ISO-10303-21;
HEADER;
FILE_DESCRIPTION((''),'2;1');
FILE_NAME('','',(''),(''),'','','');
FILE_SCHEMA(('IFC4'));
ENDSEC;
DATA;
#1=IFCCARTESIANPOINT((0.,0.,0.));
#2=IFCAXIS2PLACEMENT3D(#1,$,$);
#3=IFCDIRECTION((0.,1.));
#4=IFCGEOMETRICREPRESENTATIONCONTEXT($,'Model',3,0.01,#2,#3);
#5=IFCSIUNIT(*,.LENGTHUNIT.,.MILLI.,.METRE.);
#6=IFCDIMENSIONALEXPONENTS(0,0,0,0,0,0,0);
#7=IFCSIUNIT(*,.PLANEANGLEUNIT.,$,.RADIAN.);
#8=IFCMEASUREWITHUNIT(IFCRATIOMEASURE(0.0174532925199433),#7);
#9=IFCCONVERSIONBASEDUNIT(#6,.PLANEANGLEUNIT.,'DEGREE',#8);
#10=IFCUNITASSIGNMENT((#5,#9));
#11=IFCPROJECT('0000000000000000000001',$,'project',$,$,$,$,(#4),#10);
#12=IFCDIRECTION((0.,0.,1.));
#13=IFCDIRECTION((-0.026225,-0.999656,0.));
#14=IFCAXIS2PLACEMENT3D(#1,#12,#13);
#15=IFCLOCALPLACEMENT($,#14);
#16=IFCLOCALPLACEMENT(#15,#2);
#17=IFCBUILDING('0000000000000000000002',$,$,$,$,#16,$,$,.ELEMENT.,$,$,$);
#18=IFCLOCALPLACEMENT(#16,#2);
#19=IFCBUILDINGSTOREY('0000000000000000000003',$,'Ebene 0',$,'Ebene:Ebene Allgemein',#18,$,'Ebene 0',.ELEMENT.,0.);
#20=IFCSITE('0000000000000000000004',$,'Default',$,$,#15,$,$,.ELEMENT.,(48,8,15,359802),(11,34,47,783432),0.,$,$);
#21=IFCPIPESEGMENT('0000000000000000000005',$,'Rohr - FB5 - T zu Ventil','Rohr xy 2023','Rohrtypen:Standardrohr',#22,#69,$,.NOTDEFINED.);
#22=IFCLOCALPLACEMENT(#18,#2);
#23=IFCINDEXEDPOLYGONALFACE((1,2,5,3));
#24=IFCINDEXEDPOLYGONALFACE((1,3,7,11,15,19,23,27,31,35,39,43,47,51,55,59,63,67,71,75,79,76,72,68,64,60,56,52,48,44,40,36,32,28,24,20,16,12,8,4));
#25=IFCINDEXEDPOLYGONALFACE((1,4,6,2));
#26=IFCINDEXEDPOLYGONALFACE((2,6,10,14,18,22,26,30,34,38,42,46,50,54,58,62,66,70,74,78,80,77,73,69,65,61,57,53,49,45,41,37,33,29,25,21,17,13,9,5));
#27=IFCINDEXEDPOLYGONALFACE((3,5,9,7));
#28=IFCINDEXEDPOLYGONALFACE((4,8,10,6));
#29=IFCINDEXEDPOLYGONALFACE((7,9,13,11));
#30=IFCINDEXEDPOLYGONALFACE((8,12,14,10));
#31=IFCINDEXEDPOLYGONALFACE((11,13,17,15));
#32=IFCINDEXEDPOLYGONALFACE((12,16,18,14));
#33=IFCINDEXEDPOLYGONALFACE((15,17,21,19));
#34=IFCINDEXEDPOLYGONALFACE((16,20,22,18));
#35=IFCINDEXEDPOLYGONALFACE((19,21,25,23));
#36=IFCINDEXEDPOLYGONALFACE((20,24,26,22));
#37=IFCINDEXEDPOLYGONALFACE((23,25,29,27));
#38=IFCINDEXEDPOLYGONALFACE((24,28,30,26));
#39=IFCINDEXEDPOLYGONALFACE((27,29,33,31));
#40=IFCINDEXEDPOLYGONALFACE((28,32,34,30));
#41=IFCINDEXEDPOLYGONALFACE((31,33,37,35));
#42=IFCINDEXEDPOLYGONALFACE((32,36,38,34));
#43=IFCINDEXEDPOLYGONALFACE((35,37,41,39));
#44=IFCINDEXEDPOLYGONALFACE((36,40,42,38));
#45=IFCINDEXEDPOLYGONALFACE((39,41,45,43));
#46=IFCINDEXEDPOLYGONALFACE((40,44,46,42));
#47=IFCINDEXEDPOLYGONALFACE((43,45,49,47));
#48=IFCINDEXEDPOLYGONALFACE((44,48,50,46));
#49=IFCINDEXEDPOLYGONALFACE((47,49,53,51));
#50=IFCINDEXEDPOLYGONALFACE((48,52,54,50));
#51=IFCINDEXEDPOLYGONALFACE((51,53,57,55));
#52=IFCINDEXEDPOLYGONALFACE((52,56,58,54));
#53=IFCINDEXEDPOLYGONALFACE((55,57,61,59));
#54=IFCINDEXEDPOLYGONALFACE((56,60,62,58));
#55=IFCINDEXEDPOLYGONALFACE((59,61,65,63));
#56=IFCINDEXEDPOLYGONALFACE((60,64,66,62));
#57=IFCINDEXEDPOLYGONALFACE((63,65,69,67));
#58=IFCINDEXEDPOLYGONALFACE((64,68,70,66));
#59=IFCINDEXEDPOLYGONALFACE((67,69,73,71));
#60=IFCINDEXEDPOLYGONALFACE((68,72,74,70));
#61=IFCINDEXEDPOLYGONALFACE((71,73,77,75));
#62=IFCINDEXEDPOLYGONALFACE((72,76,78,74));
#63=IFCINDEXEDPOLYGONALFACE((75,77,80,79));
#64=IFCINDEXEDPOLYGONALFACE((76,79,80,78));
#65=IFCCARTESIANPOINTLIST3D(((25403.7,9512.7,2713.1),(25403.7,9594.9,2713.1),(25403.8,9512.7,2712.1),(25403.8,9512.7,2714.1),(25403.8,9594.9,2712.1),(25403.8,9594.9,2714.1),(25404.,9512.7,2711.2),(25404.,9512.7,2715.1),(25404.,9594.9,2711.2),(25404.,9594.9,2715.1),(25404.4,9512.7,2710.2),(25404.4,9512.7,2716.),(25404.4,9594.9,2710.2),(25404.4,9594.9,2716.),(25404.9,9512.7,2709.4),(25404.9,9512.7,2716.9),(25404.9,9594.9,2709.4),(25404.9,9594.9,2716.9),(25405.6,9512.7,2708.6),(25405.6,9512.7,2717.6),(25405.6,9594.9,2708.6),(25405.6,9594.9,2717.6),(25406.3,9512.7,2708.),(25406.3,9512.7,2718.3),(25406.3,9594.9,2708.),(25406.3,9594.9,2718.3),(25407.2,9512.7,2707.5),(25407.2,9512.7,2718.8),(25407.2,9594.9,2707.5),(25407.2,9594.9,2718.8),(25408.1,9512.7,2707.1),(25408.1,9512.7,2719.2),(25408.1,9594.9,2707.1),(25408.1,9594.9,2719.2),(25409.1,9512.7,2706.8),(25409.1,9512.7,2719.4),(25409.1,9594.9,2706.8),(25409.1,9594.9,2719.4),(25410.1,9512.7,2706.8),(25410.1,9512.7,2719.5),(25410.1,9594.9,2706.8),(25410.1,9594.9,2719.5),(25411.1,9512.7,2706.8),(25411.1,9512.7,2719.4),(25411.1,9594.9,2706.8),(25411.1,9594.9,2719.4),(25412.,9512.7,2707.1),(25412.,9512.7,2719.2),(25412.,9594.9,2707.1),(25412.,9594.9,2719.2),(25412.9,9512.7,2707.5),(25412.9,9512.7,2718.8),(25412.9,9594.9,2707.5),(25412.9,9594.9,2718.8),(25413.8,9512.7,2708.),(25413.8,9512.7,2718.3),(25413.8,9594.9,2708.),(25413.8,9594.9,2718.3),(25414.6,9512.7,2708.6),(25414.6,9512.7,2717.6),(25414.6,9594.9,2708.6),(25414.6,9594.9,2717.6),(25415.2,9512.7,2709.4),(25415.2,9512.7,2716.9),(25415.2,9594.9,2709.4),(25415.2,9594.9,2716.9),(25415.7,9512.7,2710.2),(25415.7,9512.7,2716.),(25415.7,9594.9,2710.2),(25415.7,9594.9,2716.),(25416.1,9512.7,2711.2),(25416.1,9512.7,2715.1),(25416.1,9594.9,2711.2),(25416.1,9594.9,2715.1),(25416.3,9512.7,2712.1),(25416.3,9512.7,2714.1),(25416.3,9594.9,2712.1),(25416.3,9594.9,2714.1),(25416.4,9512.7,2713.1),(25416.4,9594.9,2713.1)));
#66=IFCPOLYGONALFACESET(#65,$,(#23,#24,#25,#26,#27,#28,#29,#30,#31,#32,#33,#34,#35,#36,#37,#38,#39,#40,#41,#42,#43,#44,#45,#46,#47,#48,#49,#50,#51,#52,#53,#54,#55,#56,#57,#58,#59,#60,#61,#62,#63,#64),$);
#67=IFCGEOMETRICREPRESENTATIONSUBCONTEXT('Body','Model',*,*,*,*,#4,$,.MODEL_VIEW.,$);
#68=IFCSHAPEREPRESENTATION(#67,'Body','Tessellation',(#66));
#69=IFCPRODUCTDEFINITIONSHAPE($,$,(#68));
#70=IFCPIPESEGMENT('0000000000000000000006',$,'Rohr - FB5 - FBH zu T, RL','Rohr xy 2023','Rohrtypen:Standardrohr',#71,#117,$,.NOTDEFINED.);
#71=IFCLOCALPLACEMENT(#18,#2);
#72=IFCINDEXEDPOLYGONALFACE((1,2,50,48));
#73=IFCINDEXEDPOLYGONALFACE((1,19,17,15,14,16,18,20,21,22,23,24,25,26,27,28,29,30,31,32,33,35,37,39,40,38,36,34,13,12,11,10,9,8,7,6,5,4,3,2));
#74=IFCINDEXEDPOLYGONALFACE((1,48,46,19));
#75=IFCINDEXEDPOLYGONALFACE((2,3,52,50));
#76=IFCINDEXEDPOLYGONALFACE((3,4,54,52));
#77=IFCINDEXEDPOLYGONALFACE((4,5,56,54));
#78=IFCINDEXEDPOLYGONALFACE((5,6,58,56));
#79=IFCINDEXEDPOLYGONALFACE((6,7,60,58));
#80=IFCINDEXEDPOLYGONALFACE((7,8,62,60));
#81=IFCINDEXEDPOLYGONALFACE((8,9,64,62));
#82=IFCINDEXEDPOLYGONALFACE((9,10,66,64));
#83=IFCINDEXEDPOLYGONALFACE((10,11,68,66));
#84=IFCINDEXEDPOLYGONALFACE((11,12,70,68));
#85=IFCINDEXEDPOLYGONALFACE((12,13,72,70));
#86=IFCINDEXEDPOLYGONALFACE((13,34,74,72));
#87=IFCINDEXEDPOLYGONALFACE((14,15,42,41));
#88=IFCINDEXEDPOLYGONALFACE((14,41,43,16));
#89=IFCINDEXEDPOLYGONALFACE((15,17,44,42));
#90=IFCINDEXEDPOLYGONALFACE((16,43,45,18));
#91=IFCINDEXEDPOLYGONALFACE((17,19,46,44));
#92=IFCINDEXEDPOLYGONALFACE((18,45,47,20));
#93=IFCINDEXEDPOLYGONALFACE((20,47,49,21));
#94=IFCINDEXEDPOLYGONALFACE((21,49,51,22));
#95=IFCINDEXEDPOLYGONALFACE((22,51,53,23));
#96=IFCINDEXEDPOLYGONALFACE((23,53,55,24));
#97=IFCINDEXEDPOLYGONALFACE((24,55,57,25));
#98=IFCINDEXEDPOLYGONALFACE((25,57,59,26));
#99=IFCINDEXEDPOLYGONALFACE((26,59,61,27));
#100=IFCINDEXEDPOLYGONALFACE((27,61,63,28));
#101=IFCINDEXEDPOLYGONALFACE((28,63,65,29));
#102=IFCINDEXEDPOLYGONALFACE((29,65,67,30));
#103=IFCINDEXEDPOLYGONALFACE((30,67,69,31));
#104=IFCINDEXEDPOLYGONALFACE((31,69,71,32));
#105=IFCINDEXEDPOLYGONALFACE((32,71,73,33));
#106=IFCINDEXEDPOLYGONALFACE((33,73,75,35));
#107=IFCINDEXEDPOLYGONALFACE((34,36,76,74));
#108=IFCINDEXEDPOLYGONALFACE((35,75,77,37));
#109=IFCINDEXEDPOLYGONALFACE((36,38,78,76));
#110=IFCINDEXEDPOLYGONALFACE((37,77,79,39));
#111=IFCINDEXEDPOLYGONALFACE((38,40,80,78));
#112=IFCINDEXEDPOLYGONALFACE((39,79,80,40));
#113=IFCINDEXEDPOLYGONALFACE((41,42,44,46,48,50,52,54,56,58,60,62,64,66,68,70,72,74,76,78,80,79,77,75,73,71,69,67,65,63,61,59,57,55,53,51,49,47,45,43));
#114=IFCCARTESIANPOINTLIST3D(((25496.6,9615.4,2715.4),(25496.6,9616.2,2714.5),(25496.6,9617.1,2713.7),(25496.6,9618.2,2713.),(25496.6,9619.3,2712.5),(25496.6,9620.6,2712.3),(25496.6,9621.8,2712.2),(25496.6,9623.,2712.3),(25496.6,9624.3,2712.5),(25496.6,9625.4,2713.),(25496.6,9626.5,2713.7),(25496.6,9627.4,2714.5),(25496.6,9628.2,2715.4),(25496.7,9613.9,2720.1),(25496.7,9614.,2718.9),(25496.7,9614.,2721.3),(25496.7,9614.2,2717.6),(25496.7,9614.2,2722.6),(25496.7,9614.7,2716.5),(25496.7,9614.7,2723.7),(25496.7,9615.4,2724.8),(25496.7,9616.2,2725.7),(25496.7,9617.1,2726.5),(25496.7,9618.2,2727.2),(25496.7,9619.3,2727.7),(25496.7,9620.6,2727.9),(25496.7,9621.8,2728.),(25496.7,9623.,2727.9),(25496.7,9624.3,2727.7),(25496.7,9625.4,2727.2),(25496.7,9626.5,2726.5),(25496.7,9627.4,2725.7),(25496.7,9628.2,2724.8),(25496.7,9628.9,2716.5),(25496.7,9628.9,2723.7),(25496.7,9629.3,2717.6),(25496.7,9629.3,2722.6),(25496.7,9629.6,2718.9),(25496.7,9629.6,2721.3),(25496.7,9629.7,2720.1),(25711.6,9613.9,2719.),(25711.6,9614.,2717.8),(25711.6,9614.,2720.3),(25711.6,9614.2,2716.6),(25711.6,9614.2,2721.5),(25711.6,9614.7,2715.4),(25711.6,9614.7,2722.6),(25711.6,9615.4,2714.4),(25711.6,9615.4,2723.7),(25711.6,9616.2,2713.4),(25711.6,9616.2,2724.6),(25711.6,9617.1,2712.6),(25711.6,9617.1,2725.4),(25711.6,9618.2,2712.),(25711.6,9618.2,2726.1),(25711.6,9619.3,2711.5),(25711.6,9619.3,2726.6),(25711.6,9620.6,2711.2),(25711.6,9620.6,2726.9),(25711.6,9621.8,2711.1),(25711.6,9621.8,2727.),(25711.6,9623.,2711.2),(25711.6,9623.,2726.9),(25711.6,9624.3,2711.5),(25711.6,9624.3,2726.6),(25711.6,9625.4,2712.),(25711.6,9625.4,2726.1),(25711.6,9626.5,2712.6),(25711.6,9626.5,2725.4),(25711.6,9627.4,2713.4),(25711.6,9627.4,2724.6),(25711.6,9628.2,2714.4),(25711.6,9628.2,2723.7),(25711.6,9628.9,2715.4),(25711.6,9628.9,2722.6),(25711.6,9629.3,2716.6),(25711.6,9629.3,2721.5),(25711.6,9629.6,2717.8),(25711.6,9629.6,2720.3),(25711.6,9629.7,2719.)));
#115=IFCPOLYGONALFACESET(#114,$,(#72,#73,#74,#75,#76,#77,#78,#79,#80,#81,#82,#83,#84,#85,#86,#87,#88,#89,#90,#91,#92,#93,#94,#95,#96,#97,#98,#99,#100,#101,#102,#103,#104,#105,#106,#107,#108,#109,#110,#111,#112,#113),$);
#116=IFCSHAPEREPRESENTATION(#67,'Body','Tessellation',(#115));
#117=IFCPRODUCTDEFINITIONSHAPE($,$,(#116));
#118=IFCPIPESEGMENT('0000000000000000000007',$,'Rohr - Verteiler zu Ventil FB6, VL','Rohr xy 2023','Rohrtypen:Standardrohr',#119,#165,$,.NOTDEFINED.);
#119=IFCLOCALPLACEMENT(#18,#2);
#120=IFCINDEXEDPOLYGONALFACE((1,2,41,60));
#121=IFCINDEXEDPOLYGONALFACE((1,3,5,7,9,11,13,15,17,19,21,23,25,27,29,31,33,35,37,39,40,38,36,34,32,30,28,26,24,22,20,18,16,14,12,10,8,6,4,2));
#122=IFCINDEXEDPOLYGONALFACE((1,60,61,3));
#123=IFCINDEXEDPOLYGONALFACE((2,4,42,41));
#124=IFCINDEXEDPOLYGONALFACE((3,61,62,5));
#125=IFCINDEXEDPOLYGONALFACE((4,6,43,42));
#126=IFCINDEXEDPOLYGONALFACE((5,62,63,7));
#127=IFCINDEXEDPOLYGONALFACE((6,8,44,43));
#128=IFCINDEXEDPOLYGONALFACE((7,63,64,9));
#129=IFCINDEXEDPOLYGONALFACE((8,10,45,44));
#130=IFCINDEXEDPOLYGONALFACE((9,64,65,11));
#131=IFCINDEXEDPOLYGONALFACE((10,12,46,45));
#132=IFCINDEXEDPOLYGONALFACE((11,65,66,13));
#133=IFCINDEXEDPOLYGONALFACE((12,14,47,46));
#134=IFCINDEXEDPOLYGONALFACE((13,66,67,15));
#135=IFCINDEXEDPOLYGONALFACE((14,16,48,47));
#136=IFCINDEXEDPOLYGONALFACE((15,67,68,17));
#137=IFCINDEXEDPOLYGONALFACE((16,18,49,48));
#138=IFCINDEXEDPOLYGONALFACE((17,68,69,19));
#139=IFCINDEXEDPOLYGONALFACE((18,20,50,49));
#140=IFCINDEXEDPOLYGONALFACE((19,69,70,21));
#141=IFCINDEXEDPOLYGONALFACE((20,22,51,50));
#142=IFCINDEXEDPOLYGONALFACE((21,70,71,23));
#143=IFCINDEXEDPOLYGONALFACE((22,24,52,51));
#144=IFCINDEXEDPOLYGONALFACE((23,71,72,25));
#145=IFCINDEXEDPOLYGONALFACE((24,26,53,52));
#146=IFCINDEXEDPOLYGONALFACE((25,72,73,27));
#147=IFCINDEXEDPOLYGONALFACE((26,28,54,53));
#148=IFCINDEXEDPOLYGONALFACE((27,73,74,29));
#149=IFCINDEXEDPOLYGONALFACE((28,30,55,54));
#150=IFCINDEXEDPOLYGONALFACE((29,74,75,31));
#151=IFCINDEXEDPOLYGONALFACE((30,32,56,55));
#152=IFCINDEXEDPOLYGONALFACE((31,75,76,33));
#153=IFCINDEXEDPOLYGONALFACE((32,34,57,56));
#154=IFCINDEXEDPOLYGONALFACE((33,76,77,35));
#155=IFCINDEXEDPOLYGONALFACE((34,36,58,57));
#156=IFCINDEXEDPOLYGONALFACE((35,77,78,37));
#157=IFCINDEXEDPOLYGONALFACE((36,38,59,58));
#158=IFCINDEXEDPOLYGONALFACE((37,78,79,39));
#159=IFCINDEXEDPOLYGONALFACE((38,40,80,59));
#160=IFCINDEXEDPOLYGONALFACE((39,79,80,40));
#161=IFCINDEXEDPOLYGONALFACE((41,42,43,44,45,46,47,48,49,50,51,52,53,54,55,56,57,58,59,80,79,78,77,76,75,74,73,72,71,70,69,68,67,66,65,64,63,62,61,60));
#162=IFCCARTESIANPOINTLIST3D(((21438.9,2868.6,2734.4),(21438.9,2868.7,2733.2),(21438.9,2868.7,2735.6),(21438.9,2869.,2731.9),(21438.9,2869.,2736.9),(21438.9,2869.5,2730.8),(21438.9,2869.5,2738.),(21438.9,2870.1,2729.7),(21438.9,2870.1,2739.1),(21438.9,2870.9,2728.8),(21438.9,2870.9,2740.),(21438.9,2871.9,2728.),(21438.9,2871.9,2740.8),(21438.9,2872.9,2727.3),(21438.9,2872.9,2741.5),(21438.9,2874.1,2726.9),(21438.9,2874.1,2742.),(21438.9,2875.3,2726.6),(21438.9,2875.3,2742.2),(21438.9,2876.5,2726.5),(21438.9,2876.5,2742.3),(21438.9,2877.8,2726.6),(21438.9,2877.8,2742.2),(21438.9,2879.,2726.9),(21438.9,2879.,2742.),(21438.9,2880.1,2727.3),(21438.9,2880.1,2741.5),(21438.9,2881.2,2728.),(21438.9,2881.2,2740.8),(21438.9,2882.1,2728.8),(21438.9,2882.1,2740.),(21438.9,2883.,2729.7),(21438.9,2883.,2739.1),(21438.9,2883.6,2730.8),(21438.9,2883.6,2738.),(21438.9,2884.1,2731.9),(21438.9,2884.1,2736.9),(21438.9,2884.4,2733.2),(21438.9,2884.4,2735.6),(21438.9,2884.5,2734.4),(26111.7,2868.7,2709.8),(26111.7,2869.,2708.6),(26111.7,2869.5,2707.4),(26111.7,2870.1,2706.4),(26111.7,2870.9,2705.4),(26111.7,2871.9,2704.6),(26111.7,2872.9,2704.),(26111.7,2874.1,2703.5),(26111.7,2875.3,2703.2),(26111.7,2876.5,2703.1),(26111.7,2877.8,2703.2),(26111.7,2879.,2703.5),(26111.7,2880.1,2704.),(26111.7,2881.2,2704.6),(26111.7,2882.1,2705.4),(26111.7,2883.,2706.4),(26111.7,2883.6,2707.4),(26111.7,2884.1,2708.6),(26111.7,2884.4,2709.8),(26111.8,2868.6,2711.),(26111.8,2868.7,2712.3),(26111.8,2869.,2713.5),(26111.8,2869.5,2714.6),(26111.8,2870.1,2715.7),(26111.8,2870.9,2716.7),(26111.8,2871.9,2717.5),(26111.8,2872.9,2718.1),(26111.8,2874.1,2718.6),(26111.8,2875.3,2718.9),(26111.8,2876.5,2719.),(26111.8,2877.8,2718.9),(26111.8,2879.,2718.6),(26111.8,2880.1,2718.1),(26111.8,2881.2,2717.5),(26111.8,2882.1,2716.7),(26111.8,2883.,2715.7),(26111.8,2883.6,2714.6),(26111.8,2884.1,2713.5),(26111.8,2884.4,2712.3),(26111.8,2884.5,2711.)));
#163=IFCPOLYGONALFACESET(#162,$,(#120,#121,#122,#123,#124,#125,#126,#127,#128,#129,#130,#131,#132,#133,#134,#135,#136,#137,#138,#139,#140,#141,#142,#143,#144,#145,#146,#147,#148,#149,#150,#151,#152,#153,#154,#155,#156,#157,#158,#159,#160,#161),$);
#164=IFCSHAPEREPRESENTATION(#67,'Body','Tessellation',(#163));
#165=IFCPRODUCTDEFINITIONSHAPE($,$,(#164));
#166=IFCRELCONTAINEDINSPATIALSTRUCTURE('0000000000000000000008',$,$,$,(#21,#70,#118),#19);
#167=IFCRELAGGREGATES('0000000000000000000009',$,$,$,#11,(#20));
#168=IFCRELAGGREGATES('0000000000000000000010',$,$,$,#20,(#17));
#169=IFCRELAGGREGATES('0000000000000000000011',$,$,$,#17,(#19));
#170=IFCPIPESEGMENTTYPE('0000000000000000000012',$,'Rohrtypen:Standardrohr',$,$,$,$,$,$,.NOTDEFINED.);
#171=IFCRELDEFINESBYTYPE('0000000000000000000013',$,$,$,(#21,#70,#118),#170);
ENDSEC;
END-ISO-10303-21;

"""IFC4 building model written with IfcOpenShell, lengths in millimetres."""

from ifc_helpers import new_model, entity, si_unit, converted_unit, direction, frame, origin, place, context, subcontext, project, spatial, indexed_curve, outline, extrude, type_object, element, save


model = new_model("IFC4")

# Units and contexts
model_context = context("Model", 3, precision=0.01, world=origin(), true_north=direction((0.0, 1.0)))
body_context = subcontext(model_context, "Body", "Model", "MODEL_VIEW")
ifc_project = project(units=[si_unit("LENGTHUNIT", "METRE", prefix="MILLI"), converted_unit("PLANEANGLEUNIT", "DEGREE", entity("IfcRatioMeasure", 0.0174532925199433), si_unit("PLANEANGLEUNIT", "RADIAN"), dimensions=[0, 0, 0, 0, 0, 0, 0])], contexts=[model_context])

# Site, building, storey
site_placement = place(None, frame((0.0, 0.0, 0.0), z_axis=(0.0, 0.0, 1.0), x_axis=(-0.026225, -0.999656, 0.0)))
site = spatial("IfcSite", under=ifc_project, at=site_placement, Name="Default", CompositionType="ELEMENT", RefLatitude=(48, 8, 15, 359802), RefLongitude=(11, 34, 47, 783432), RefElevation=0.0)
building_placement = place(site_placement, origin())
building = spatial("IfcBuilding", under=site, at=building_placement, CompositionType="ELEMENT")
storey_placement = place(building_placement, origin())
storey = spatial("IfcBuildingStorey", under=building, at=storey_placement, Name="Ebene 0", ObjectType="Ebene:Ebene Allgemein", LongName="Ebene 0", CompositionType="ELEMENT", Elevation=0.0)

# Pipe segments
pipe_segment_type = type_object("IfcPipeSegmentType", Name="Rohrtypen:Standardrohr", PredefinedType="NOTDEFINED")
pipe_segment_1_placement = place(storey_placement, origin())
element("IfcPipeSegment", 1, at=pipe_segment_1_placement, inside=storey, type_object=pipe_segment_type, Name="Rohr - FB5 - T zu Ventil", Description="Rohr xy 2023", ObjectType="Rohrtypen:Standardrohr", PredefinedType="NOTDEFINED", context=body_context, shape_type="SweptSolid", body=[
    extrude(outline(indexed_curve([(6.3, 0.0), (6.3, 1.0), (6.0, 2.0), (5.7, 2.9), (5.1, 3.7), (4.5, 4.5), (3.7, 5.1), (2.9, 5.7), (2.0, 6.0), (1.0, 6.3), (0.0, 6.4), (-1.0, 6.3), (-2.0, 6.0), (-2.9, 5.7), (-3.7, 5.1), (-4.5, 4.5), (-5.1, 3.7), (-5.7, 2.9), (-6.0, 2.0), (-6.3, 1.0), (-6.3, 0.0), (-6.3, -1.0), (-6.0, -2.0), (-5.7, -2.9), (-5.1, -3.7), (-4.5, -4.5), (-3.7, -5.1), (-2.9, -5.7), (-2.0, -6.0), (-1.0, -6.3), (0.0, -6.4), (1.0, -6.3), (2.0, -6.0), (2.9, -5.7), (3.7, -5.1), (4.5, -4.5), (5.1, -3.7), (5.7, -2.9), (6.0, -2.0), (6.3, -1.0), (6.3, 0.0)], self_intersect=False)), frame((25410.1, 9512.7, 2713.1), z_axis=(0.0, 1.0, 0.0), x_axis=(-1.0, 0.0, 0.0)), (0.0, 0.0, 1.0), 82.2),
])
pipe_segment_2_placement = place(storey_placement, origin())
element("IfcPipeSegment", 2, at=pipe_segment_2_placement, inside=storey, type_object=pipe_segment_type, Name="Rohr - FB5 - FBH zu T, RL", Description="Rohr xy 2023", ObjectType="Rohrtypen:Standardrohr", PredefinedType="NOTDEFINED", context=body_context, shape_type="SweptSolid", body=[
    extrude(outline(indexed_curve([(7.9, 0.0), (7.8, 1.2), (7.6, 2.5), (7.1, 3.6), (6.4, 4.7), (5.6, 5.6), (4.7, 6.4), (3.6, 7.1), (2.5, 7.6), (1.2, 7.8), (0.0, 7.9), (-1.2, 7.8), (-2.5, 7.6), (-3.6, 7.1), (-4.7, 6.4), (-5.6, 5.6), (-6.4, 4.7), (-7.1, 3.6), (-7.6, 2.5), (-7.8, 1.2), (-7.9, 0.0), (-7.8, -1.2), (-7.6, -2.5), (-7.1, -3.6), (-6.4, -4.7), (-5.6, -5.6), (-4.7, -6.4), (-3.6, -7.1), (-2.5, -7.6), (-1.2, -7.8), (0.0, -7.9), (1.2, -7.8), (2.5, -7.6), (3.6, -7.1), (4.7, -6.4), (5.6, -5.6), (6.4, -4.7), (7.1, -3.6), (7.6, -2.5), (7.8, -1.2), (7.9, 0.0)], self_intersect=False)), frame((25711.6, 9621.8, 2719.0), z_axis=(-0.999988, 0.0, 0.005), x_axis=(0.0, 1.0, 0.0)), (0.0, 0.0, 1.0), 214.9),
])
pipe_segment_3_placement = place(storey_placement, origin())
element("IfcPipeSegment", 3, at=pipe_segment_3_placement, inside=storey, type_object=pipe_segment_type, Name="Rohr - Verteiler zu Ventil FB6, VL", Description="Rohr xy 2023", ObjectType="Rohrtypen:Standardrohr", PredefinedType="NOTDEFINED", context=body_context, shape_type="SweptSolid", body=[
    extrude(outline(indexed_curve([(7.9, 0.0), (7.8, 1.2), (7.6, 2.5), (7.1, 3.6), (6.4, 4.7), (5.6, 5.6), (4.7, 6.4), (3.6, 7.1), (2.5, 7.6), (1.2, 7.8), (0.0, 7.9), (-1.2, 7.8), (-2.5, 7.6), (-3.6, 7.1), (-4.7, 6.4), (-5.6, 5.6), (-6.4, 4.7), (-7.1, 3.6), (-7.6, 2.5), (-7.8, 1.2), (-7.9, 0.0), (-7.8, -1.2), (-7.6, -2.5), (-7.1, -3.6), (-6.4, -4.7), (-5.6, -5.6), (-4.7, -6.4), (-3.6, -7.1), (-2.5, -7.6), (-1.2, -7.8), (0.0, -7.9), (1.2, -7.8), (2.5, -7.6), (3.6, -7.1), (4.7, -6.4), (5.6, -5.6), (6.4, -4.7), (7.1, -3.6), (7.6, -2.5), (7.8, -1.2), (7.9, 0.0)], self_intersect=False)), frame((26111.8, 2876.5, 2711.0), z_axis=(-0.999988, 0.0, 0.005), x_axis=(0.0, 1.0, 0.0)), (0.0, 0.0, 1.0), 4672.9),
])

save(model, "model.ifc")
